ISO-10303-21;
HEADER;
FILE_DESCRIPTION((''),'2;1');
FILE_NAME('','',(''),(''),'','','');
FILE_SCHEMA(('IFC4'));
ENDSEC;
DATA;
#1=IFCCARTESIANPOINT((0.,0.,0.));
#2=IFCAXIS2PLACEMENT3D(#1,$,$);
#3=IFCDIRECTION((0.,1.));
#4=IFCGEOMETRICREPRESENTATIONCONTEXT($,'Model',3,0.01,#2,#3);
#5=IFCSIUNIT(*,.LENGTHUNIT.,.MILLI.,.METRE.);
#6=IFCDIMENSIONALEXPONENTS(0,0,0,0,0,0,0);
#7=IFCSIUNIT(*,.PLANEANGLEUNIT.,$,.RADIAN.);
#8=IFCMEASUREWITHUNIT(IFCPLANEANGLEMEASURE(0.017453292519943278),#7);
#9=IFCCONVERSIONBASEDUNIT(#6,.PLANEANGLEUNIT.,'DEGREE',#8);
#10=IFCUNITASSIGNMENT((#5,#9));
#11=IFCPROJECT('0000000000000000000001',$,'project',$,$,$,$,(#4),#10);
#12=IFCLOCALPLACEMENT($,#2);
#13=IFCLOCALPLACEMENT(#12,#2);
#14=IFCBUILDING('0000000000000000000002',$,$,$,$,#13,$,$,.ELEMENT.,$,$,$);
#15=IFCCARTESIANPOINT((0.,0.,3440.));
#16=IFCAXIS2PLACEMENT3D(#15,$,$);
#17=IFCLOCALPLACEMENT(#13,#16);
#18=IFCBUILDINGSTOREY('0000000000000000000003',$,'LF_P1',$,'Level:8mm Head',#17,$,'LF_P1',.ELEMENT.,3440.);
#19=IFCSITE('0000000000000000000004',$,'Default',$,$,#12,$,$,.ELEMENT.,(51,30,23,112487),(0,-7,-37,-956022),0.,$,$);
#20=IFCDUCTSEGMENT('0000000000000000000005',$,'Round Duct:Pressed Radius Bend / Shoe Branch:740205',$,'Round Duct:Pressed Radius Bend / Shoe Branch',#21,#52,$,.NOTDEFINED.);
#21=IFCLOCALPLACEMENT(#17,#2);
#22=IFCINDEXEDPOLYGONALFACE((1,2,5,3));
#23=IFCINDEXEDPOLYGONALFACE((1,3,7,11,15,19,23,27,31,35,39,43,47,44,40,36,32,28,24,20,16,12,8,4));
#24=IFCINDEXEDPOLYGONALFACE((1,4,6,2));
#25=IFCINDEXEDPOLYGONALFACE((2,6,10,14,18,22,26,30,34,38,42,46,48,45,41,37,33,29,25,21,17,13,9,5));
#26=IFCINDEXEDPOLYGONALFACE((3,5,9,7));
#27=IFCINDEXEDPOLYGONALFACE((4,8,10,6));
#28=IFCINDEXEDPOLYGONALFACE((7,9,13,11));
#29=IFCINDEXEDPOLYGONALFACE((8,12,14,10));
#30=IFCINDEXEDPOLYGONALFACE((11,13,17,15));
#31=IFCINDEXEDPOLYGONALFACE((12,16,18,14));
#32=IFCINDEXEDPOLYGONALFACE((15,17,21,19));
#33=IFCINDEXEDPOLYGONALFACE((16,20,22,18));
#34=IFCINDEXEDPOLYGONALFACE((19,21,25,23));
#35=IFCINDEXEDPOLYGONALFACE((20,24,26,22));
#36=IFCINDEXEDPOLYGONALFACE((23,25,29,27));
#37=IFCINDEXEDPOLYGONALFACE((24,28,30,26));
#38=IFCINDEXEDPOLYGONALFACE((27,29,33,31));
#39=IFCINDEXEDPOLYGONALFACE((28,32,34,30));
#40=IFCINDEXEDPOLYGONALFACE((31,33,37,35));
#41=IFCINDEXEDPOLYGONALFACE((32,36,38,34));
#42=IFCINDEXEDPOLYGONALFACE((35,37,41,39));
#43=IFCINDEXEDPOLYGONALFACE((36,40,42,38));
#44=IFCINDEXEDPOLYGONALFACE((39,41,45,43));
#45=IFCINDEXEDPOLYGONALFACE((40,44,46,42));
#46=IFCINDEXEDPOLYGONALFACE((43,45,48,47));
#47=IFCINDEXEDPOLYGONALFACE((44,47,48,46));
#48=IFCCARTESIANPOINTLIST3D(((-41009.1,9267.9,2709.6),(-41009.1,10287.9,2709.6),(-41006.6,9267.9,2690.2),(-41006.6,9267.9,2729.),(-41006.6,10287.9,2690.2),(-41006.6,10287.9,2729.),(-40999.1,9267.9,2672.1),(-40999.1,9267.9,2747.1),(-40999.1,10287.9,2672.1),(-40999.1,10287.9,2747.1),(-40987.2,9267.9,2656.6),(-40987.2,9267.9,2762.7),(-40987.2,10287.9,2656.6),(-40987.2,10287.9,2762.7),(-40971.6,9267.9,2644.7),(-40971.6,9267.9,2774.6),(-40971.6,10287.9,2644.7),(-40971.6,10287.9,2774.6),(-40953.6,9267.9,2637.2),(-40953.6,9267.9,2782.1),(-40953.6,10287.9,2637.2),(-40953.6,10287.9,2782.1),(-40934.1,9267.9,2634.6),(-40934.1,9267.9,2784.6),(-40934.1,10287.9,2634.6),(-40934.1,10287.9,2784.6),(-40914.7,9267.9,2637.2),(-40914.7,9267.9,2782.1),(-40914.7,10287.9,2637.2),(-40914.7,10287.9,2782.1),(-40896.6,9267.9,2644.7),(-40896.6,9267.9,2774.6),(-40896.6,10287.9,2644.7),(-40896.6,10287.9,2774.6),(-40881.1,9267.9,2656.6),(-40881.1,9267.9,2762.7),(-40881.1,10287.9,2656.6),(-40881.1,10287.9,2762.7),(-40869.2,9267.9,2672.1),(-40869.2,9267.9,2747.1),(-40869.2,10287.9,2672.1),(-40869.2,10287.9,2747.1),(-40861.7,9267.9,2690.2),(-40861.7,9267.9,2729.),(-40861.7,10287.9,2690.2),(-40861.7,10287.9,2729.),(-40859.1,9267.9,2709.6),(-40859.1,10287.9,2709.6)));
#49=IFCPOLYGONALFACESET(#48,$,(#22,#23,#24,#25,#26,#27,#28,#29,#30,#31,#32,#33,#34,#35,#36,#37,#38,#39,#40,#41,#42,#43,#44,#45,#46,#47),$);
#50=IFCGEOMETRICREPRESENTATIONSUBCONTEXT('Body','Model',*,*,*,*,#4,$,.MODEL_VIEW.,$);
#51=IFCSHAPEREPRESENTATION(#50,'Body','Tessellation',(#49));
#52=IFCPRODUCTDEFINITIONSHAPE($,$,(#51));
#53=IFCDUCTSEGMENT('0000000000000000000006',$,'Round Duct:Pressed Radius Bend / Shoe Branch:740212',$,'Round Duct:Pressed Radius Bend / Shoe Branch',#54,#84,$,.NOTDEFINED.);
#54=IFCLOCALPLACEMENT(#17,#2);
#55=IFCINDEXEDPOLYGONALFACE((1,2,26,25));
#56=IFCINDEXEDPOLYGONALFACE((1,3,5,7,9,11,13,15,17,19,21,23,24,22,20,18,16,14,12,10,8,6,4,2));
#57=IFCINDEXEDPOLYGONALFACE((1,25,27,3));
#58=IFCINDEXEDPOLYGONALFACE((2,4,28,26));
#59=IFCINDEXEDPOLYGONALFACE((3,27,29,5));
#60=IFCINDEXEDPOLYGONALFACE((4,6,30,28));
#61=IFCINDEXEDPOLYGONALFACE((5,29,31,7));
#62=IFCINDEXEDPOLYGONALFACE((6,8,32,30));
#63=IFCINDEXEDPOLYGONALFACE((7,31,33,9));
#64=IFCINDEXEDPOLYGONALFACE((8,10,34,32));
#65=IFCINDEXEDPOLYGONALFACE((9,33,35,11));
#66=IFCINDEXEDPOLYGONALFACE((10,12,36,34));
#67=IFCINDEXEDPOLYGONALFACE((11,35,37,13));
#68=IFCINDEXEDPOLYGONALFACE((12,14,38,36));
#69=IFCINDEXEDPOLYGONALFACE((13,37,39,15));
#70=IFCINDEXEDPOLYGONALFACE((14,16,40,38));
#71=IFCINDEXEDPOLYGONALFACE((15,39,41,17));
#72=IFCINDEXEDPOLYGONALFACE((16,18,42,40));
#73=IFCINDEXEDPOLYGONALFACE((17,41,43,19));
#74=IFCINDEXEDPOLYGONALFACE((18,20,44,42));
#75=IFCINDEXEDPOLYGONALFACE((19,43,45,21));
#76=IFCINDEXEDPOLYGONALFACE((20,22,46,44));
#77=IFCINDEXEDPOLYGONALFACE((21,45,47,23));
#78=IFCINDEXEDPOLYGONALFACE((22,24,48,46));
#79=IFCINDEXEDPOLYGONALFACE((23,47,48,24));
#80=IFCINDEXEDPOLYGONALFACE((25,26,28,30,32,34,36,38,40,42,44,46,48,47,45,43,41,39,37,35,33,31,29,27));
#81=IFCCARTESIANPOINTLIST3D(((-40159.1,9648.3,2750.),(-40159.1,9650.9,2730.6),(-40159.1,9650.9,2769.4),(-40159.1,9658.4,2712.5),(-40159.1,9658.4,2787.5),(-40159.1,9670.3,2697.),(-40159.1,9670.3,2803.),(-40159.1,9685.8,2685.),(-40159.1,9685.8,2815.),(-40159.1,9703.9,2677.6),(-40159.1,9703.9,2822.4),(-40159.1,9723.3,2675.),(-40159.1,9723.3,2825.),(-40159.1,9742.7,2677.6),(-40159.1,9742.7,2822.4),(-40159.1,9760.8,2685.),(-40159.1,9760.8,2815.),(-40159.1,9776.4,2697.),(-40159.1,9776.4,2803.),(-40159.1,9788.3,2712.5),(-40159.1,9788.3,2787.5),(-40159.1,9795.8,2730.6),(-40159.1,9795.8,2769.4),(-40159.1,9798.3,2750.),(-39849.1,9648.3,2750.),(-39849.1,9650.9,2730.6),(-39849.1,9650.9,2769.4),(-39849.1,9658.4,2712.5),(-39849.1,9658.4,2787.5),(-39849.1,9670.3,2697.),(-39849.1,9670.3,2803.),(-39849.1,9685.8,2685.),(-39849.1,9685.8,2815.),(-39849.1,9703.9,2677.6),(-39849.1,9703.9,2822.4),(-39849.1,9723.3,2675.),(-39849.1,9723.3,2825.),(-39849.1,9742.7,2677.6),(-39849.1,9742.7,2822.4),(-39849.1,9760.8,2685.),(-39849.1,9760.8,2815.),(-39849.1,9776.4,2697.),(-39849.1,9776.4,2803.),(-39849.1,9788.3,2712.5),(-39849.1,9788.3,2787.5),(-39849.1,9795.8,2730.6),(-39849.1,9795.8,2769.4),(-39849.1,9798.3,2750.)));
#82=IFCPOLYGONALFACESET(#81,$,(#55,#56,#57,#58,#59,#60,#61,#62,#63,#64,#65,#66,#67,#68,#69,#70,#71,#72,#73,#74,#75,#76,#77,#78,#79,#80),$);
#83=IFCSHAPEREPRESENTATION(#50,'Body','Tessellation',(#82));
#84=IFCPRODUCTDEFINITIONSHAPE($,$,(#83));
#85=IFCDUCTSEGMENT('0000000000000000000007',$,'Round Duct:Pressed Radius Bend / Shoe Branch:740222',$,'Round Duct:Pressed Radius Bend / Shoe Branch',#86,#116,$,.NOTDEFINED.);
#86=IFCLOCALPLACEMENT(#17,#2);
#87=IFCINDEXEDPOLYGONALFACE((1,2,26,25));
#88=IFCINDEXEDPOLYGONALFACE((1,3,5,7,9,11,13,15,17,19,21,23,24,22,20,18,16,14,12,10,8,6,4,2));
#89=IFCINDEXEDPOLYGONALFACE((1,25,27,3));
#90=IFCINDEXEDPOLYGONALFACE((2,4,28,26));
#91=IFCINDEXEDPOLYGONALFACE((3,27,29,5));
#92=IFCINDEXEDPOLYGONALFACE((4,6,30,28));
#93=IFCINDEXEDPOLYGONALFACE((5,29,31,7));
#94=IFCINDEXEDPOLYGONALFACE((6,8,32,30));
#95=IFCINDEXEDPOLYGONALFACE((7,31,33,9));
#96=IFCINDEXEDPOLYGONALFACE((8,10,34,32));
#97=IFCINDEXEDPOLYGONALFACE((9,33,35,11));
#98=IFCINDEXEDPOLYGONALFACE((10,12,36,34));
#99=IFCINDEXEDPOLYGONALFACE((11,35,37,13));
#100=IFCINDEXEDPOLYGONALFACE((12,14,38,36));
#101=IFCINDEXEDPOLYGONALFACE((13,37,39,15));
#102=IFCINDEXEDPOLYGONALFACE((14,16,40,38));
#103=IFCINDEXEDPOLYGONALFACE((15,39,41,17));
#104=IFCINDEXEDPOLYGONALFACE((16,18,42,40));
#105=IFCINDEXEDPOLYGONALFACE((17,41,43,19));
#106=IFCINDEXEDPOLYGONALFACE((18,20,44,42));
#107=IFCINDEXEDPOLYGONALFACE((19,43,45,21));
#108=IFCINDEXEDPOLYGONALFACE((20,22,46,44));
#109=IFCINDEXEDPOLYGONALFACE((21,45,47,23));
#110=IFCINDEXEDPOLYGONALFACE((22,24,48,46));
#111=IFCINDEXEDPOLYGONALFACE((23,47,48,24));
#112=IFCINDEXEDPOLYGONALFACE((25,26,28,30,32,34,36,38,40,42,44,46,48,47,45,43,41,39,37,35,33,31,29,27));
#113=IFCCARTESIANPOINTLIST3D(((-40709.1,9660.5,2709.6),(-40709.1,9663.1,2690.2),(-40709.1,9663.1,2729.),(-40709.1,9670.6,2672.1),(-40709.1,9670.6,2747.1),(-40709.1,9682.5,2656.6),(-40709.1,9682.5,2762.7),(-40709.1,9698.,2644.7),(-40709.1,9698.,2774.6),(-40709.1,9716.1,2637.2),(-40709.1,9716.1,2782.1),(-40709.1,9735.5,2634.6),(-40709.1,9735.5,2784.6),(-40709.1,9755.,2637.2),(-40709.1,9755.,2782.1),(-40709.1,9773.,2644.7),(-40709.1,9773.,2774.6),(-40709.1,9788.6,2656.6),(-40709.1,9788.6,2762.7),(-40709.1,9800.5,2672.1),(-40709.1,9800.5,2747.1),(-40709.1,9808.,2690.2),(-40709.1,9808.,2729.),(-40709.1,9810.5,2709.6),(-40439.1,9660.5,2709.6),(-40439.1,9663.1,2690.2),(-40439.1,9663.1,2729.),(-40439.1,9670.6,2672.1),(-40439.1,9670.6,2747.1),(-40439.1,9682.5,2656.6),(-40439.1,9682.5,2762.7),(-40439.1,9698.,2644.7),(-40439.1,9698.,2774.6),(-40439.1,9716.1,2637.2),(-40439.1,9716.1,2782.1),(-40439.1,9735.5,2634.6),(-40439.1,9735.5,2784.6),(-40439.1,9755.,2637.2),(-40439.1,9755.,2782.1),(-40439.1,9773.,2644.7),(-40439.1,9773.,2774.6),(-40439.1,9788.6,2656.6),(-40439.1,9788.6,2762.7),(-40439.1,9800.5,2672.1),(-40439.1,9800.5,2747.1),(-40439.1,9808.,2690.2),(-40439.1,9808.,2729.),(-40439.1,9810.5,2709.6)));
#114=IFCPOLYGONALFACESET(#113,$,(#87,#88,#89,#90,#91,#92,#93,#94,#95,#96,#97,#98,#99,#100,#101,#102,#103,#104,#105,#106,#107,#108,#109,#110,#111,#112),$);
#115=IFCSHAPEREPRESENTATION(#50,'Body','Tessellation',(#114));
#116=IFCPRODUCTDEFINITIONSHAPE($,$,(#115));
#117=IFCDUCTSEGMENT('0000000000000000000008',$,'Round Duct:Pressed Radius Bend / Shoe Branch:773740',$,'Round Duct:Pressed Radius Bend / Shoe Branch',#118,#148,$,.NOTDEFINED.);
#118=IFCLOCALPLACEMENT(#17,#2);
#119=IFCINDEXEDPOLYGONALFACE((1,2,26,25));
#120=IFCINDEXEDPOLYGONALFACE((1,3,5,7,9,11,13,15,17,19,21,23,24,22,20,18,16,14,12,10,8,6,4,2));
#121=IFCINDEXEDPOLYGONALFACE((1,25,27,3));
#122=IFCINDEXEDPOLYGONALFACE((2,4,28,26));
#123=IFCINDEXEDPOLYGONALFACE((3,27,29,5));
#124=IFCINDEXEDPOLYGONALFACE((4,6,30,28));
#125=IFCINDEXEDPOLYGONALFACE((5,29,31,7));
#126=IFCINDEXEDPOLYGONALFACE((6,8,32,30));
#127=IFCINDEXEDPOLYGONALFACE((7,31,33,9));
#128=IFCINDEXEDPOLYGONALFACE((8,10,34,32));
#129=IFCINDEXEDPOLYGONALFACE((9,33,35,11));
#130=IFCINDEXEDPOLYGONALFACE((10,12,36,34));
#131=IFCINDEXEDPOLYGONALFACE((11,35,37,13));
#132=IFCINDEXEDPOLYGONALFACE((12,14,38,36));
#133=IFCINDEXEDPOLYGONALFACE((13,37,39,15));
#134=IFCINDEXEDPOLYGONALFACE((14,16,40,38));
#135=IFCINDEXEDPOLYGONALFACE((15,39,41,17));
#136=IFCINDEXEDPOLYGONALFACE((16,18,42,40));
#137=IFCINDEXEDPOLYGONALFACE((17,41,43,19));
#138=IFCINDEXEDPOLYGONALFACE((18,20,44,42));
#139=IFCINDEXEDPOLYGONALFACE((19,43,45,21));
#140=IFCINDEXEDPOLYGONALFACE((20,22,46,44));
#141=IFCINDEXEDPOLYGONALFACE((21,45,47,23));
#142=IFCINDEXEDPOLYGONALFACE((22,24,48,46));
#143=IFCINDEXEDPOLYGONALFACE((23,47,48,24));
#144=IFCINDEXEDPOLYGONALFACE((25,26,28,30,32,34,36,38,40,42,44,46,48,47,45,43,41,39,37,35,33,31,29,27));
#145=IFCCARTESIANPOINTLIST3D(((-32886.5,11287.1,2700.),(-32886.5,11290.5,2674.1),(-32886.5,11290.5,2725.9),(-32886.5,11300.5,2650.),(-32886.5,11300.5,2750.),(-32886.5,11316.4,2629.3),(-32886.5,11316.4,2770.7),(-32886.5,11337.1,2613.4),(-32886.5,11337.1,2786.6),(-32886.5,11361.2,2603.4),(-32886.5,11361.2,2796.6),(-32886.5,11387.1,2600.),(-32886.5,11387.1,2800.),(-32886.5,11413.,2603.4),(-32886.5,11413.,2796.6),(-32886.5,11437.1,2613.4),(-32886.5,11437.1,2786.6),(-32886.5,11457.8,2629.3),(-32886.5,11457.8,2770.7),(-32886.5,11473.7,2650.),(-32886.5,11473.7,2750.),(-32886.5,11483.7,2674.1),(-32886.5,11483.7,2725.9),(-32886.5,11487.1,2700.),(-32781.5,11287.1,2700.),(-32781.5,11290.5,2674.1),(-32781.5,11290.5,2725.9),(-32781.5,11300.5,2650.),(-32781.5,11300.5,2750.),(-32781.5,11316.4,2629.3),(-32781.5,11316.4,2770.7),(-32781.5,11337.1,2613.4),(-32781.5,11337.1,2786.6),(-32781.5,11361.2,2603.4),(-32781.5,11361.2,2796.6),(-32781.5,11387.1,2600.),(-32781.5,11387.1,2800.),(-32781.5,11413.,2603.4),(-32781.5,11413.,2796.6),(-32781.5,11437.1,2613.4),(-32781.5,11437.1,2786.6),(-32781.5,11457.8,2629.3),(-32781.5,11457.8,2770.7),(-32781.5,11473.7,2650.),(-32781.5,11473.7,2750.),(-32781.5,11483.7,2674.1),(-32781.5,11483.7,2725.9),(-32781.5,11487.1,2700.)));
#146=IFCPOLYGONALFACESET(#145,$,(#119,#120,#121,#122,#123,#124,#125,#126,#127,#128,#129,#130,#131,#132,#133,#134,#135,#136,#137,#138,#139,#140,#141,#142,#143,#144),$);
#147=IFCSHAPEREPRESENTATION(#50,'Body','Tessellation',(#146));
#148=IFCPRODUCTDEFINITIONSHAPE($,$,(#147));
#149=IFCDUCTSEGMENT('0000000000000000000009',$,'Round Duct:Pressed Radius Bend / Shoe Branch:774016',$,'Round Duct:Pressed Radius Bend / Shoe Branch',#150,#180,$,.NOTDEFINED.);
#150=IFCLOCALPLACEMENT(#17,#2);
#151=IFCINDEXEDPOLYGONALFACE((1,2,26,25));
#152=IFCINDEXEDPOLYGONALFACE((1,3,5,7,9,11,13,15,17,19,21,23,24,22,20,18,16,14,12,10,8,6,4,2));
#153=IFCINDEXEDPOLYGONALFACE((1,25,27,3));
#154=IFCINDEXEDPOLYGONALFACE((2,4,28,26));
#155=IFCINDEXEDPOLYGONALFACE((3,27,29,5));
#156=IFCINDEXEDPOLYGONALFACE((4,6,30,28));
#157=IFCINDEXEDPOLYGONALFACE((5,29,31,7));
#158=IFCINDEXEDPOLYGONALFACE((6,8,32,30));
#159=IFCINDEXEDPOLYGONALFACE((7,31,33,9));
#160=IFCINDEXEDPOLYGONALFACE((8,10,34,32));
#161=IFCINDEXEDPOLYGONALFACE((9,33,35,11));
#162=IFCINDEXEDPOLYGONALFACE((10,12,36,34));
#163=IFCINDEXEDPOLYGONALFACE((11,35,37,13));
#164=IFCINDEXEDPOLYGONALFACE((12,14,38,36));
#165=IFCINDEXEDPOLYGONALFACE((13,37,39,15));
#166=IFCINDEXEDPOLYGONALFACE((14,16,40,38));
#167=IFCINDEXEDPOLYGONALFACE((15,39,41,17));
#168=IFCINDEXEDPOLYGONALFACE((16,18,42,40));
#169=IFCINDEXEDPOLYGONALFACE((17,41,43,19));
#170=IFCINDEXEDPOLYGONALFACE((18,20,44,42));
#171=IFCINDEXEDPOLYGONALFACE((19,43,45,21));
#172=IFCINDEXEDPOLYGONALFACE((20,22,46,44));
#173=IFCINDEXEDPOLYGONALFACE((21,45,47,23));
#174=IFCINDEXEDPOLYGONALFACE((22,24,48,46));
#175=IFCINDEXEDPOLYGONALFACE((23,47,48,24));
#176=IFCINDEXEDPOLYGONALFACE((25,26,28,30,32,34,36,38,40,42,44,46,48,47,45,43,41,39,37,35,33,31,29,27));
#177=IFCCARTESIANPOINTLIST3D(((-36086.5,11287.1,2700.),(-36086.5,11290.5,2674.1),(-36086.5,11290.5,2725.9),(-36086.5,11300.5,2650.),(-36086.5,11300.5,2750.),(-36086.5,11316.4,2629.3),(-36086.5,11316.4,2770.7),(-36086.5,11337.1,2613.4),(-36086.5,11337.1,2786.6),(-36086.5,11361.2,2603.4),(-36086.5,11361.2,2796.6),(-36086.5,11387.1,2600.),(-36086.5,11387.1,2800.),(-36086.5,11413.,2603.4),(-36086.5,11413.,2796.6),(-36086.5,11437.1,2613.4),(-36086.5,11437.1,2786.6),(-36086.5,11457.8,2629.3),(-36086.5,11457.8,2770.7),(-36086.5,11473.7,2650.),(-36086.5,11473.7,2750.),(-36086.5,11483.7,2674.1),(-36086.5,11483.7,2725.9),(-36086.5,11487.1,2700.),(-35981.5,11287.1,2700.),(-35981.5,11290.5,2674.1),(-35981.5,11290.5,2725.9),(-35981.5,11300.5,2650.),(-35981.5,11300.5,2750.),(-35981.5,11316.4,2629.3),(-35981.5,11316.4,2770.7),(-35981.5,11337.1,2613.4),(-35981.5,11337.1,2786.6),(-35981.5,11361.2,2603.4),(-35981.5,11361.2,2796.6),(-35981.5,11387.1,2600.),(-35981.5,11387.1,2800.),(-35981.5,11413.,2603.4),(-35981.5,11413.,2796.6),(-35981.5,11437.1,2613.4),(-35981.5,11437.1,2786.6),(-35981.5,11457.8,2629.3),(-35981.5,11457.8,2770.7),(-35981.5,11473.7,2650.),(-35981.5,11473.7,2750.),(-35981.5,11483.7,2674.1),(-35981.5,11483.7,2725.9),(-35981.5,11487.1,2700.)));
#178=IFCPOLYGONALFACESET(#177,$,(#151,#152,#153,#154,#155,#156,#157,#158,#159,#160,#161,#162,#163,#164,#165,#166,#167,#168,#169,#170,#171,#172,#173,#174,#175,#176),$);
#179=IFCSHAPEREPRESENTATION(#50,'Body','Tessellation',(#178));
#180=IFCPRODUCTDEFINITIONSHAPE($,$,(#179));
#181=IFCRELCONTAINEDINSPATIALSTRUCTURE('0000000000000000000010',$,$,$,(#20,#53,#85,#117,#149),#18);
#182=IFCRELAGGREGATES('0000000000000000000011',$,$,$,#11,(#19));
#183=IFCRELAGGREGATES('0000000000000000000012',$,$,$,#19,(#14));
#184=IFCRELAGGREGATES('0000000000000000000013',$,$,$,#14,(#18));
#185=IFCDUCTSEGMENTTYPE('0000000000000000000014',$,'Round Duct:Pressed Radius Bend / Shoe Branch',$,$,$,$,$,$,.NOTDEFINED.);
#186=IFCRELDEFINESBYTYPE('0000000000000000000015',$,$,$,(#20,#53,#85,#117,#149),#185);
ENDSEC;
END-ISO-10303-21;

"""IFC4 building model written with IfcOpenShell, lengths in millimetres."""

from ifc_helpers import new_model, entity, si_unit, converted_unit, direction, frame, origin, place, context, subcontext, project, spatial, arc, indexed_curve, outline, extrude, type_object, element, save


model = new_model("IFC4")

# Units and contexts
model_context = context("Model", 3, precision=0.01, world=origin(), true_north=direction((0.0, 1.0)))
body_context = subcontext(model_context, "Body", "Model", "MODEL_VIEW")
ifc_project = project(units=[si_unit("LENGTHUNIT", "METRE", prefix="MILLI"), converted_unit("PLANEANGLEUNIT", "DEGREE", entity("IfcPlaneAngleMeasure", 0.017453292519943278), si_unit("PLANEANGLEUNIT", "RADIAN"), dimensions=[0, 0, 0, 0, 0, 0, 0])], contexts=[model_context])

# Site, building, storey
site_placement = place(None, origin())
site = spatial("IfcSite", under=ifc_project, at=site_placement, Name="Default", CompositionType="ELEMENT", RefLatitude=(51, 30, 23, 112487), RefLongitude=(0, -7, -37, -956022), RefElevation=0.0)
building_placement = place(site_placement, origin())
building = spatial("IfcBuilding", under=site, at=building_placement, CompositionType="ELEMENT")
storey_placement = place(building_placement, frame((0.0, 0.0, 3440.0)))
storey = spatial("IfcBuildingStorey", under=building, at=storey_placement, Name="LF_P1", ObjectType="Level:8mm Head", LongName="LF_P1", CompositionType="ELEMENT", Elevation=3440.0)

# Duct segments
duct_segment_type_1 = type_object("IfcDuctSegmentType", Name="Round Duct:Pressed Radius Bend / Shoe Branch", PredefinedType="NOTDEFINED")
duct_segment_1_placement = place(storey_placement, origin())
element("IfcDuctSegment", 1, at=duct_segment_1_placement, inside=storey, type_object=duct_segment_type_1, Name="Round Duct:Pressed Radius Bend / Shoe Branch:740205", ObjectType="Round Duct:Pressed Radius Bend / Shoe Branch", PredefinedType="NOTDEFINED", context=body_context, shape_type="SweptSolid", body=[
    extrude(outline(indexed_curve([(75.0, 0.0), (53.0, 53.0), (0.0, 75.0), (-53.0, 53.0), (-75.0, 0.0), (-53.0, -53.0), (0.0, -75.0), (53.0, -53.0)], segments=[arc(1, 2, 3), arc(3, 4, 5), arc(5, 6, 7), arc(7, 8, 1)], self_intersect=False)), frame((-40934.1, 9267.9, 2709.6), z_axis=(0.0, 1.0, 0.0), x_axis=(1.0, 0.0, 0.0)), (0.0, 0.0, 1.0), 1020.0),
])
duct_segment_2_placement = place(storey_placement, origin())
element("IfcDuctSegment", 2, at=duct_segment_2_placement, inside=storey, type_object=duct_segment_type_1, Name="Round Duct:Pressed Radius Bend / Shoe Branch:740212", ObjectType="Round Duct:Pressed Radius Bend / Shoe Branch", PredefinedType="NOTDEFINED", context=body_context, shape_type="SweptSolid", body=[
    extrude(outline(indexed_curve([(75.0, 0.0), (53.0, 53.0), (0.0, 75.0), (-53.0, 53.0), (-75.0, 0.0), (-53.0, -53.0), (0.0, -75.0), (53.0, -53.0)], segments=[arc(1, 2, 3), arc(3, 4, 5), arc(5, 6, 7), arc(7, 8, 1)], self_intersect=False)), frame((-40159.1, 9723.3, 2750.0), z_axis=(1.0, 0.0, 0.0), x_axis=(0.0, 1.0, 0.0)), (0.0, 0.0, 1.0), 310.0),
])
duct_segment_3_placement = place(storey_placement, origin())
element("IfcDuctSegment", 3, at=duct_segment_3_placement, inside=storey, type_object=duct_segment_type_1, Name="Round Duct:Pressed Radius Bend / Shoe Branch:740222", ObjectType="Round Duct:Pressed Radius Bend / Shoe Branch", PredefinedType="NOTDEFINED", context=body_context, shape_type="SweptSolid", body=[
    extrude(outline(indexed_curve([(75.0, 0.0), (53.0, 53.0), (0.0, 75.0), (-53.0, 53.0), (-75.0, 0.0), (-53.0, -53.0), (0.0, -75.0), (53.0, -53.0)], segments=[arc(1, 2, 3), arc(3, 4, 5), arc(5, 6, 7), arc(7, 8, 1)], self_intersect=False)), frame((-40709.1, 9735.5, 2709.6), z_axis=(1.0, 0.0, 0.0), x_axis=(0.0, -1.0, 0.0)), (0.0, 0.0, 1.0), 270.0),
])
duct_segment_4_placement = place(storey_placement, origin())
element("IfcDuctSegment", 4, at=duct_segment_4_placement, inside=storey, type_object=duct_segment_type_1, Name="Round Duct:Pressed Radius Bend / Shoe Branch:773740", ObjectType="Round Duct:Pressed Radius Bend / Shoe Branch", PredefinedType="NOTDEFINED", context=body_context, shape_type="SweptSolid", body=[
    extrude(outline(indexed_curve([(100.0, 0.0), (70.7, 70.7), (0.0, 100.0), (-70.7, 70.7), (-100.0, 0.0), (-70.7, -70.7), (0.0, -100.0), (70.7, -70.7)], segments=[arc(1, 2, 3), arc(3, 4, 5), arc(5, 6, 7), arc(7, 8, 1)], self_intersect=False)), frame((-32886.5, 11387.1, 2700.0), z_axis=(1.0, 0.0, 0.0), x_axis=(0.0, 1.0, 0.0)), (0.0, 0.0, 1.0), 105.0),
])
duct_segment_5_placement = place(storey_placement, origin())
element("IfcDuctSegment", 5, at=duct_segment_5_placement, inside=storey, type_object=duct_segment_type_1, Name="Round Duct:Pressed Radius Bend / Shoe Branch:774016", ObjectType="Round Duct:Pressed Radius Bend / Shoe Branch", PredefinedType="NOTDEFINED", context=body_context, shape_type="SweptSolid", body=[
    extrude(outline(indexed_curve([(100.0, 0.0), (70.7, 70.7), (0.0, 100.0), (-70.7, 70.7), (-100.0, 0.0), (-70.7, -70.7), (0.0, -100.0), (70.7, -70.7)], segments=[arc(1, 2, 3), arc(3, 4, 5), arc(5, 6, 7), arc(7, 8, 1)], self_intersect=False)), frame((-36086.5, 11387.1, 2700.0), z_axis=(1.0, 0.0, 0.0), x_axis=(0.0, 1.0, 0.0)), (0.0, 0.0, 1.0), 105.0),
])

save(model, "model.ifc")
